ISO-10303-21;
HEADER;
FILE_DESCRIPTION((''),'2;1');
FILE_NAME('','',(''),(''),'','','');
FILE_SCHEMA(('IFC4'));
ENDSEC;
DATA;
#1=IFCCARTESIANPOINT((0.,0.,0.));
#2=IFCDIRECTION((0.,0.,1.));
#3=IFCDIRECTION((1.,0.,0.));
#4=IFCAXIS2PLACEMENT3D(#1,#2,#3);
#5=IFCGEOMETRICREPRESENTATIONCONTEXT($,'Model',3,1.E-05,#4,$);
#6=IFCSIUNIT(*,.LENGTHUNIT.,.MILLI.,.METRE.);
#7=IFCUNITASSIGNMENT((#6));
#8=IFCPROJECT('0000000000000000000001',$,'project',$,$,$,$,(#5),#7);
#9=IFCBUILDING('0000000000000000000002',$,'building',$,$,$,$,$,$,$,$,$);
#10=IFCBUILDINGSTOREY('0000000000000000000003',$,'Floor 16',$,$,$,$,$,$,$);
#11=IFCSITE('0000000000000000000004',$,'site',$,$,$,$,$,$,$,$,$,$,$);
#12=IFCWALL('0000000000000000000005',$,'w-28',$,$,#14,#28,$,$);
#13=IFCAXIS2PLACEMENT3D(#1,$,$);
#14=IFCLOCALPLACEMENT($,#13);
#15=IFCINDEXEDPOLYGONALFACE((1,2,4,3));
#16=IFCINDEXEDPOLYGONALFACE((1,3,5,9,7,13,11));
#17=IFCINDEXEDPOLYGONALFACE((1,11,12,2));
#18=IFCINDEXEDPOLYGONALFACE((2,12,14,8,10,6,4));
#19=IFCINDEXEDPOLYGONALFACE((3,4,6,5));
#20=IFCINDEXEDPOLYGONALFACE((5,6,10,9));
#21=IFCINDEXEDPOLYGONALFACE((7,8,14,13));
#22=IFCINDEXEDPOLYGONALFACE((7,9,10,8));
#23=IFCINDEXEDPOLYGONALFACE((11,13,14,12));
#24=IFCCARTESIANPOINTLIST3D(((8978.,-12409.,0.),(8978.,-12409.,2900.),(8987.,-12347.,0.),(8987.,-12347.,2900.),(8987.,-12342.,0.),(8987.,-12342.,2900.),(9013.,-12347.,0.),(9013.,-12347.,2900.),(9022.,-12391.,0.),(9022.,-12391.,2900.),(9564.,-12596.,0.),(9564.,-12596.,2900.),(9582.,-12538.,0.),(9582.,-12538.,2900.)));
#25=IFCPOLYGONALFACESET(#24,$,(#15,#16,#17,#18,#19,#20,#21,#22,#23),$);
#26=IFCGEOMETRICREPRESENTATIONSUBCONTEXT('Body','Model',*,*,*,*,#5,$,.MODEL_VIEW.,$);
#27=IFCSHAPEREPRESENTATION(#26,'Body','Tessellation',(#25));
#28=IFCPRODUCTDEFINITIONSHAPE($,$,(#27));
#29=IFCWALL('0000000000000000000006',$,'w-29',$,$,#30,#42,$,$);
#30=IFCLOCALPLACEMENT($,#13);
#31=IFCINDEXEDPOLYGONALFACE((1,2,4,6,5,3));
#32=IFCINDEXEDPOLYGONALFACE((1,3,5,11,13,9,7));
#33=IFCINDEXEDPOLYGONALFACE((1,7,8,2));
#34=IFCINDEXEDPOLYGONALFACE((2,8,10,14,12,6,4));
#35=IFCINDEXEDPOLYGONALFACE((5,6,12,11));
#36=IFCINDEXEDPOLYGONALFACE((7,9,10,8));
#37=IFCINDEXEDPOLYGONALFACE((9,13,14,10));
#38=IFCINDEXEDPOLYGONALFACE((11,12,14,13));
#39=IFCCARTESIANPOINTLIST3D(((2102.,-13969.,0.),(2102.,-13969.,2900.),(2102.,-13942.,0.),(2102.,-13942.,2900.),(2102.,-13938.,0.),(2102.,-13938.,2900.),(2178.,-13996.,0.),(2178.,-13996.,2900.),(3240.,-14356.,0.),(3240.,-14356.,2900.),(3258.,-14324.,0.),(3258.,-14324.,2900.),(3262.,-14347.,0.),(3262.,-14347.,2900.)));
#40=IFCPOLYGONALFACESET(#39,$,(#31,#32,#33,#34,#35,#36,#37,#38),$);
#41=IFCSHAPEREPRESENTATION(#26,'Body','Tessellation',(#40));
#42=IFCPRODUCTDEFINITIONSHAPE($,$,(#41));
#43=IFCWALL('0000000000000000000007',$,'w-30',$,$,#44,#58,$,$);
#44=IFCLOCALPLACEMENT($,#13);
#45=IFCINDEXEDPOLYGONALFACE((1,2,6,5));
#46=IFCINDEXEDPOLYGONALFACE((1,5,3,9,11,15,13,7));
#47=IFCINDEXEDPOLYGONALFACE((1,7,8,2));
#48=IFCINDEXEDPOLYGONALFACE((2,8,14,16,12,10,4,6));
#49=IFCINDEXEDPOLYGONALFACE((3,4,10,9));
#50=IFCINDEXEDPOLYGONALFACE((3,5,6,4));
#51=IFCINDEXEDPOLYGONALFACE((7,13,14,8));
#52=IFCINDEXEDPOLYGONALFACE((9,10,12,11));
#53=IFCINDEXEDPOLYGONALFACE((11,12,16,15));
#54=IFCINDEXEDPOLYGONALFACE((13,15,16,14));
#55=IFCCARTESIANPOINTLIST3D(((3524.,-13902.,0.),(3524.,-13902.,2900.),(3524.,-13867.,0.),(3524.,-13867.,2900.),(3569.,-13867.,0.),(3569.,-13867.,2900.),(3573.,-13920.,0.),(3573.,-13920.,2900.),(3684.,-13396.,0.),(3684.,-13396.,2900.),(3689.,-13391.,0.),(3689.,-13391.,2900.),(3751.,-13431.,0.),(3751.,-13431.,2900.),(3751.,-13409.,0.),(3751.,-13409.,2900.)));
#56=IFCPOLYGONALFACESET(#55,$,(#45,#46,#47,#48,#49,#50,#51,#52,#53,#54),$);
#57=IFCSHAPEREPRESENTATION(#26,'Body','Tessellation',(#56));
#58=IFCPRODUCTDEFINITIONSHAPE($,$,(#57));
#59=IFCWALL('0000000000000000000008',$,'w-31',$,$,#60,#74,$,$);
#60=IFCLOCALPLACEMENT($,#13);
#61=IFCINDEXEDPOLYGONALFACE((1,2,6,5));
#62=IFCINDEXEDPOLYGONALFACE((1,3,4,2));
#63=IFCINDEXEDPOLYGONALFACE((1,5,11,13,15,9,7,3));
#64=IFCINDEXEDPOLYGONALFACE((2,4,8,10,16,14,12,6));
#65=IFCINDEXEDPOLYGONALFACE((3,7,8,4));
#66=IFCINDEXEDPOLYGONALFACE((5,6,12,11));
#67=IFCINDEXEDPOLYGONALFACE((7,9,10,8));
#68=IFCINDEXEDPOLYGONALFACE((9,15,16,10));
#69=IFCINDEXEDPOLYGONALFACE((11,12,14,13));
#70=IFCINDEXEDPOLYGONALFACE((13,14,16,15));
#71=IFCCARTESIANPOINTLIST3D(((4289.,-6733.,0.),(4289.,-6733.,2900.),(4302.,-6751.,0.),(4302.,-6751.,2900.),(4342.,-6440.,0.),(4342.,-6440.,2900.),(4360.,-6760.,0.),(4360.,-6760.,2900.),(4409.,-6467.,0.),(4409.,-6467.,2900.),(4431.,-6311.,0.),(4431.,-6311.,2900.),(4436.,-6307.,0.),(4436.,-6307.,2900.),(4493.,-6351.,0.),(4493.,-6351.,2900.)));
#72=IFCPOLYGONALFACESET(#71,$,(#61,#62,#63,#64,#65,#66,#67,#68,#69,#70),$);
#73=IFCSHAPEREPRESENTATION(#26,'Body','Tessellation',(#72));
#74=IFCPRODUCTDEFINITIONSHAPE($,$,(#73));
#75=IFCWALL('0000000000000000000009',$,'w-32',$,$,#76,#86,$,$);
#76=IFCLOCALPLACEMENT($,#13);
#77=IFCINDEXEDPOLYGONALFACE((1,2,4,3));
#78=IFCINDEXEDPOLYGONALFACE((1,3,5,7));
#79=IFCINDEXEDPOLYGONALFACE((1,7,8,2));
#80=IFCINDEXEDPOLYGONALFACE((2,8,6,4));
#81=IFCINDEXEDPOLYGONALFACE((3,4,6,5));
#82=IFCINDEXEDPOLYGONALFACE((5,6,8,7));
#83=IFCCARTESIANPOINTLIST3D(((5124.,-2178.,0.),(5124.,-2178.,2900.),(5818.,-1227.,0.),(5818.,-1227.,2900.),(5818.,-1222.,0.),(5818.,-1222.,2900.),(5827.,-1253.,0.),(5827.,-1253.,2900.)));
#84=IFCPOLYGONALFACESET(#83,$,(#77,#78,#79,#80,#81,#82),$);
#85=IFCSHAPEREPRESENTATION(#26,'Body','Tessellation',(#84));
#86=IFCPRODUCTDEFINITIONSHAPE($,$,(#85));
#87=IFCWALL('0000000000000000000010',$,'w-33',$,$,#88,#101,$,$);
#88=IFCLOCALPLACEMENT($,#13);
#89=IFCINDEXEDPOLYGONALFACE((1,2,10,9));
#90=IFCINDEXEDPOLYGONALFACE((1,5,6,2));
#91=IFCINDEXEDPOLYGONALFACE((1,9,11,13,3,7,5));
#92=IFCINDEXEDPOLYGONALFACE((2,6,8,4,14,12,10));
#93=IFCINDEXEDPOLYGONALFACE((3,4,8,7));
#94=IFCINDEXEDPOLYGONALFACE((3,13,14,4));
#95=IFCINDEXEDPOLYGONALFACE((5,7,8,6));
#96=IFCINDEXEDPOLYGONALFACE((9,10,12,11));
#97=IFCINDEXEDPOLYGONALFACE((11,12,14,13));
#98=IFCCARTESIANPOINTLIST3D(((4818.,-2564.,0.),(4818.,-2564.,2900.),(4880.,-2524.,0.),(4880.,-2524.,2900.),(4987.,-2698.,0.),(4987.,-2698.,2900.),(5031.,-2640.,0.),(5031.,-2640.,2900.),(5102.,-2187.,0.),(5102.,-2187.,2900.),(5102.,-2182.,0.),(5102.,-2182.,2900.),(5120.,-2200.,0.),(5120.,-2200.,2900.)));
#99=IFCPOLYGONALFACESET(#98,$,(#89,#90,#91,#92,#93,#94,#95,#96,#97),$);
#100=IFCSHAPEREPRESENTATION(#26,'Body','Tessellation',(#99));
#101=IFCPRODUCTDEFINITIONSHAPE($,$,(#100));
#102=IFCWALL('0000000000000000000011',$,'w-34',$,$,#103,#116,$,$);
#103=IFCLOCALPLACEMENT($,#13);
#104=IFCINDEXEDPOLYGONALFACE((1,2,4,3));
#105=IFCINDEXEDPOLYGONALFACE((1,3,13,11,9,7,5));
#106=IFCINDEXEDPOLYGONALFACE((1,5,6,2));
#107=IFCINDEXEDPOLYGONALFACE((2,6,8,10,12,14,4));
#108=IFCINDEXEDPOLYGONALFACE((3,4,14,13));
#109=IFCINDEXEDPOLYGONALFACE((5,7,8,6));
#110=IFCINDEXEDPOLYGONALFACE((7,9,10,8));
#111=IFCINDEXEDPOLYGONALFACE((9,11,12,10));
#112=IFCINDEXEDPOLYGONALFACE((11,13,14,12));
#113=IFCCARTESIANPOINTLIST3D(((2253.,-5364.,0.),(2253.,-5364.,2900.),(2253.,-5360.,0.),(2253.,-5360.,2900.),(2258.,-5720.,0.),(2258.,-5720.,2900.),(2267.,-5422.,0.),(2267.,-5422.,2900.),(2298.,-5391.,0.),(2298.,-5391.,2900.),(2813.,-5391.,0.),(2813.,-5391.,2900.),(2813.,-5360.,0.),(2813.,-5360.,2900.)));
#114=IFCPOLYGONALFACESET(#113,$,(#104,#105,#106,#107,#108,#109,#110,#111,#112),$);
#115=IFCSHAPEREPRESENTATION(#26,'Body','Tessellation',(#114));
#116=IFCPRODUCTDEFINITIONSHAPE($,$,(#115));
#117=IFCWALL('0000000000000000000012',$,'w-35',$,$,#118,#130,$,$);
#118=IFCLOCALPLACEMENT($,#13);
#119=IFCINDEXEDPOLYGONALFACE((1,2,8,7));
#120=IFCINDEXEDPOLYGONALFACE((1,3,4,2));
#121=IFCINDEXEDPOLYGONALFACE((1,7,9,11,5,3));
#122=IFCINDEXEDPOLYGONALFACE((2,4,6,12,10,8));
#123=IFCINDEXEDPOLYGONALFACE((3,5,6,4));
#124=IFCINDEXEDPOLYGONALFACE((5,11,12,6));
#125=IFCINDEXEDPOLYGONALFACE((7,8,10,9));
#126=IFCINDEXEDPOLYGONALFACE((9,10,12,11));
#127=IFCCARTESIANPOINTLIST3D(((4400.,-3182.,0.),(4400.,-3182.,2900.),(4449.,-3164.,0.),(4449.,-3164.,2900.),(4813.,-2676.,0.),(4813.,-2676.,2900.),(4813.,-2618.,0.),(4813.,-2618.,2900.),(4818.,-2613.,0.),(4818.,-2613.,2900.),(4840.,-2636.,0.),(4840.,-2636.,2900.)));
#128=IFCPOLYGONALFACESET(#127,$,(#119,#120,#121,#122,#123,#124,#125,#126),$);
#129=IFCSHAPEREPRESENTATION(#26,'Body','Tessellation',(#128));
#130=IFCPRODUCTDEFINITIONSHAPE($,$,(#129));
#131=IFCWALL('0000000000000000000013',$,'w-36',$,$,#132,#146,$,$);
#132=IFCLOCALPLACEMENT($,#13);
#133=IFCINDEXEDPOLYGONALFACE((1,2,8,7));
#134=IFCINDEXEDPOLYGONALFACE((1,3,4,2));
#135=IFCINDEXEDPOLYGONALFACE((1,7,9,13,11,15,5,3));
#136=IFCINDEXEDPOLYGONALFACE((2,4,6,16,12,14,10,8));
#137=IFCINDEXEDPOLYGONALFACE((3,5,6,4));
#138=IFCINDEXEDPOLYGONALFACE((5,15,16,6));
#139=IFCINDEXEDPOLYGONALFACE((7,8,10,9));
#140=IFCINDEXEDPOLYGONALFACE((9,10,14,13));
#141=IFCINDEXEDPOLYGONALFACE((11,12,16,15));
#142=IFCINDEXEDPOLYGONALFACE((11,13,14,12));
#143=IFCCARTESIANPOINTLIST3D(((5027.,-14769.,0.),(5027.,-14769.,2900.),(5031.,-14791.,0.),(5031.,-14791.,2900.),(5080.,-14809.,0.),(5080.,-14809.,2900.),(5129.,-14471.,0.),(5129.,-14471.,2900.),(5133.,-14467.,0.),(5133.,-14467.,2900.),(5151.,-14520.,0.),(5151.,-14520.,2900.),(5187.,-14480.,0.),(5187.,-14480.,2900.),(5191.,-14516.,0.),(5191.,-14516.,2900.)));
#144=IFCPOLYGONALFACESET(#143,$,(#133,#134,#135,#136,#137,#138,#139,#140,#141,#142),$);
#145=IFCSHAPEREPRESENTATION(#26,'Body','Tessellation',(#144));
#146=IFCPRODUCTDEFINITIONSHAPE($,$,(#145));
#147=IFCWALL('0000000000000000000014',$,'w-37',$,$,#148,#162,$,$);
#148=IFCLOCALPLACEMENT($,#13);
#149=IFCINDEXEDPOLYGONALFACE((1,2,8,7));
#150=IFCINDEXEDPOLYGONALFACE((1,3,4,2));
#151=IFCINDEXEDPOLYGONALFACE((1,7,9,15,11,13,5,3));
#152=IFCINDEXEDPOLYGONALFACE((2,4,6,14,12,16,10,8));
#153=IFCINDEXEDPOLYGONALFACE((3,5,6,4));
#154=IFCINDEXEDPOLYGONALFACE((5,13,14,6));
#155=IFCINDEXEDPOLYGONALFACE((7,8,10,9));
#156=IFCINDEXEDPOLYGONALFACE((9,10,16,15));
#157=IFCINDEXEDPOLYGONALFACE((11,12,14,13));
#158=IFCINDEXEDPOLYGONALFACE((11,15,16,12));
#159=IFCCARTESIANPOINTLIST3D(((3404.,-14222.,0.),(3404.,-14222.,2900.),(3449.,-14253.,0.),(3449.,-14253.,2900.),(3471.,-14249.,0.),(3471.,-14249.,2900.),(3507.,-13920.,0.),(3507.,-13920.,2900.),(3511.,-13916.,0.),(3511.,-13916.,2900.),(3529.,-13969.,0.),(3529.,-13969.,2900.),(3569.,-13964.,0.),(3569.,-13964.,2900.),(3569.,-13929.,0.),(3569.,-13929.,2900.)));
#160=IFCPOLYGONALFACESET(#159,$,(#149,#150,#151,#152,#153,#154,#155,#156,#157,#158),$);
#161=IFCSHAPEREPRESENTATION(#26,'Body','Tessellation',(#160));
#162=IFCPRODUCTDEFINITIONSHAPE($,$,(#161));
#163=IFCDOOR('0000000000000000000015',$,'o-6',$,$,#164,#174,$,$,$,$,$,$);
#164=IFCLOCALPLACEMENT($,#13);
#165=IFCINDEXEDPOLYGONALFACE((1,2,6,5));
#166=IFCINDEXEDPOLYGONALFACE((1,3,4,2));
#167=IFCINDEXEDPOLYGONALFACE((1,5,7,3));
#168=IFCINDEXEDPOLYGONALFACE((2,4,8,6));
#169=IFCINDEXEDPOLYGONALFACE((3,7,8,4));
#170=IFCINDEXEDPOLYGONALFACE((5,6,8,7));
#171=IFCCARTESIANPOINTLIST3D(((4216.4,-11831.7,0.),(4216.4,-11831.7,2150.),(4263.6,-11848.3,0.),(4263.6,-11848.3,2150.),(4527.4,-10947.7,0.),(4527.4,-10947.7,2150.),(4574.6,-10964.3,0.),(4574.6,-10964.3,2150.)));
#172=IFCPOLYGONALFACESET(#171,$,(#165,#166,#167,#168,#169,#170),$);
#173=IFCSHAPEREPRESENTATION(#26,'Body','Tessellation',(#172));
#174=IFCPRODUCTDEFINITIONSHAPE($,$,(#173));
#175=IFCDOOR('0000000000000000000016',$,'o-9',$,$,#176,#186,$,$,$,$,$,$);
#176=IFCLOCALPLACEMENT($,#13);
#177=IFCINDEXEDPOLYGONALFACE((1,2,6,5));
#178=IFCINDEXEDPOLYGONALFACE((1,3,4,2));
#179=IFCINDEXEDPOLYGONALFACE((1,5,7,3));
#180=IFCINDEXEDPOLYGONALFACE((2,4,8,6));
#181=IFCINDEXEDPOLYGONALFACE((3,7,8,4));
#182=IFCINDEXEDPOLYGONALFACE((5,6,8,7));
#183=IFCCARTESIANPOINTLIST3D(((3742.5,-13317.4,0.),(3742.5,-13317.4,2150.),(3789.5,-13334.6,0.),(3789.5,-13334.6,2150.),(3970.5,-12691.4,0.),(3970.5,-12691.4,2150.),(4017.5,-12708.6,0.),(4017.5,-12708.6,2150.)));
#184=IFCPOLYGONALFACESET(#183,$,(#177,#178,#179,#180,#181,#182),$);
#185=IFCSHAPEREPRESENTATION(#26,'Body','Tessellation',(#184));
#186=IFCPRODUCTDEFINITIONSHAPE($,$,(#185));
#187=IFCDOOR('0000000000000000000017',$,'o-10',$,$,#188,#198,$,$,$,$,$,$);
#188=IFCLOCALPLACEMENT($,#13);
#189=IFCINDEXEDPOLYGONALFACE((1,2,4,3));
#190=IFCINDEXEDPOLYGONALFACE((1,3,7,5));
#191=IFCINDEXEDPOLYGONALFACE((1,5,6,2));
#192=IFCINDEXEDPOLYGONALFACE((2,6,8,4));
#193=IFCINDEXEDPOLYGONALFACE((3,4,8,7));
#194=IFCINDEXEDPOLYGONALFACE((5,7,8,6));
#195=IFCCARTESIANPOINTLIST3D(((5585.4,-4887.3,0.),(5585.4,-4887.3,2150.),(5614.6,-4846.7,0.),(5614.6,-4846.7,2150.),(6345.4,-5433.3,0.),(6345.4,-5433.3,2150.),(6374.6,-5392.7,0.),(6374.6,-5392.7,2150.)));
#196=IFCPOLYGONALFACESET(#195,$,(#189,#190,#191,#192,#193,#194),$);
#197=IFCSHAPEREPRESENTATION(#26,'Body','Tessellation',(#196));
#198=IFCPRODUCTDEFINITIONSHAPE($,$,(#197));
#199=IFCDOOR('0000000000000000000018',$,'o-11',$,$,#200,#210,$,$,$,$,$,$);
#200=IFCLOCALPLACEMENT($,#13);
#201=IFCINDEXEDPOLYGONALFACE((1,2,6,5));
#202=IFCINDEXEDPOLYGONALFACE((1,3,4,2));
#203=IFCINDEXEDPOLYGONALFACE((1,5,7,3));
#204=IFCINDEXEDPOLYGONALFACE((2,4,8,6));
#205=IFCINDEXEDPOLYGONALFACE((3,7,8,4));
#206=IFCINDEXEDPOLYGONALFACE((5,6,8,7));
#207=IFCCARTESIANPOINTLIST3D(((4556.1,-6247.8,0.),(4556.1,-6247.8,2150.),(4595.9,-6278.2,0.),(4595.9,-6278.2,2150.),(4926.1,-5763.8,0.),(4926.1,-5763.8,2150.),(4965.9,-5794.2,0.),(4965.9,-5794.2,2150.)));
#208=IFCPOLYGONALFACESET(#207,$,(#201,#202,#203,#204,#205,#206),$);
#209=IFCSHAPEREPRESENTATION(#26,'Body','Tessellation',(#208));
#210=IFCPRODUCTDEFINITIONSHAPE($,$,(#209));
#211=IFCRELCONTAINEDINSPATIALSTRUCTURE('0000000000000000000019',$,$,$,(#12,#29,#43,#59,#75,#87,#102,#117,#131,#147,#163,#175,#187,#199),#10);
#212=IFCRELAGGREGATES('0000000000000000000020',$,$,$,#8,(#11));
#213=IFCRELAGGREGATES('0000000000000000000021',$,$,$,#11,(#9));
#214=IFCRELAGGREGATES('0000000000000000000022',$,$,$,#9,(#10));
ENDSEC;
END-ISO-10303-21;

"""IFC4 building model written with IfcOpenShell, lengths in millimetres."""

from ifc_helpers import new_model, si_unit, origin_with_axes, place, context, subcontext, project, spatial, indexed_curve, outline, extrude, element, save


model = new_model("IFC4")

# Units and contexts
model_context = context("Model", 3, precision=1e-05, world=origin_with_axes())
body_context = subcontext(model_context, "Body", "Model", "MODEL_VIEW")
ifc_project = project(units=[si_unit("LENGTHUNIT", "METRE", prefix="MILLI")], contexts=[model_context])

# Site, building, storey
site = spatial("IfcSite", under=ifc_project, Name="site")
building = spatial("IfcBuilding", under=site, Name="building")
storey = spatial("IfcBuildingStorey", under=building, Name="Floor 16")

# Walls
wall_1_placement = place(None, origin_with_axes())
element("IfcWall", 1, at=wall_1_placement, inside=storey, Name="w-28", context=body_context, shape_type="SweptSolid", body=[
    extrude(outline(indexed_curve([(8987.0, -12342.0), (8987.0, -12347.0), (8978.0, -12409.0), (9564.0, -12596.0), (9582.0, -12538.0), (9013.0, -12347.0), (9022.0, -12391.0)])), None, (0.0, 0.0, 1.0), 2900.0),
])
wall_2_placement = place(None, origin_with_axes())
element("IfcWall", 2, at=wall_2_placement, inside=storey, Name="w-29", context=body_context, shape_type="SweptSolid", body=[
    extrude(outline(indexed_curve([(2102.0, -13938.0), (2102.0, -13942.0), (2102.0, -13969.0), (2178.0, -13996.0), (3240.0, -14356.0), (3262.0, -14347.0), (3258.0, -14324.0)])), None, (0.0, 0.0, 1.0), 2900.0),
])
wall_3_placement = place(None, origin_with_axes())
element("IfcWall", 3, at=wall_3_placement, inside=storey, Name="w-30", context=body_context, shape_type="SweptSolid", body=[
    extrude(outline(indexed_curve([(3689.0, -13391.0), (3684.0, -13396.0), (3524.0, -13867.0), (3569.0, -13867.0), (3524.0, -13902.0), (3573.0, -13920.0), (3751.0, -13431.0), (3751.0, -13409.0)])), None, (0.0, 0.0, 1.0), 2900.0),
])
wall_4_placement = place(None, origin_with_axes())
element("IfcWall", 4, at=wall_4_placement, inside=storey, Name="w-31", context=body_context, shape_type="SweptSolid", body=[
    extrude(outline(indexed_curve([(4436.0, -6307.0), (4431.0, -6311.0), (4342.0, -6440.0), (4289.0, -6733.0), (4302.0, -6751.0), (4360.0, -6760.0), (4409.0, -6467.0), (4493.0, -6351.0)])), None, (0.0, 0.0, 1.0), 2900.0),
])
wall_5_placement = place(None, origin_with_axes())
element("IfcWall", 5, at=wall_5_placement, inside=storey, Name="w-32", context=body_context, shape_type="SweptSolid", body=[
    extrude(outline(indexed_curve([(5818.0, -1222.0), (5818.0, -1227.0), (5124.0, -2178.0), (5827.0, -1253.0)])), None, (0.0, 0.0, 1.0), 2900.0),
])
wall_6_placement = place(None, origin_with_axes())
element("IfcWall", 6, at=wall_6_placement, inside=storey, Name="w-33", context=body_context, shape_type="SweptSolid", body=[
    extrude(outline(indexed_curve([(5102.0, -2182.0), (5102.0, -2187.0), (4818.0, -2564.0), (4987.0, -2698.0), (5031.0, -2640.0), (4880.0, -2524.0), (5120.0, -2200.0)])), None, (0.0, 0.0, 1.0), 2900.0),
])
wall_7_placement = place(None, origin_with_axes())
element("IfcWall", 7, at=wall_7_placement, inside=storey, Name="w-34", context=body_context, shape_type="SweptSolid", body=[
    extrude(outline(indexed_curve([(2253.0, -5360.0), (2253.0, -5364.0), (2258.0, -5720.0), (2267.0, -5422.0), (2298.0, -5391.0), (2813.0, -5391.0), (2813.0, -5360.0)])), None, (0.0, 0.0, 1.0), 2900.0),
])
wall_8_placement = place(None, origin_with_axes())
element("IfcWall", 8, at=wall_8_placement, inside=storey, Name="w-35", context=body_context, shape_type="SweptSolid", body=[
    extrude(outline(indexed_curve([(4818.0, -2613.0), (4813.0, -2618.0), (4400.0, -3182.0), (4449.0, -3164.0), (4813.0, -2676.0), (4840.0, -2636.0)])), None, (0.0, 0.0, 1.0), 2900.0),
])
wall_9_placement = place(None, origin_with_axes())
element("IfcWall", 9, at=wall_9_placement, inside=storey, Name="w-36", context=body_context, shape_type="SweptSolid", body=[
    extrude(outline(indexed_curve([(5133.0, -14467.0), (5129.0, -14471.0), (5027.0, -14769.0), (5031.0, -14791.0), (5080.0, -14809.0), (5191.0, -14516.0), (5151.0, -14520.0), (5187.0, -14480.0)])), None, (0.0, 0.0, 1.0), 2900.0),
])
wall_10_placement = place(None, origin_with_axes())
element("IfcWall", 10, at=wall_10_placement, inside=storey, Name="w-37", context=body_context, shape_type="SweptSolid", body=[
    extrude(outline(indexed_curve([(3511.0, -13916.0), (3507.0, -13920.0), (3404.0, -14222.0), (3449.0, -14253.0), (3471.0, -14249.0), (3569.0, -13964.0), (3529.0, -13969.0), (3569.0, -13929.0)])), None, (0.0, 0.0, 1.0), 2900.0),
])

# Doors
door_1_placement = place(None, origin_with_axes())
element("IfcDoor", 11, at=door_1_placement, inside=storey, Name="o-6", context=body_context, shape_type="SweptSolid", body=[
    extrude(outline(indexed_curve([(4216.4, -11831.7), (4527.4, -10947.7), (4574.6, -10964.3), (4263.6, -11848.3)])), None, (0.0, 0.0, 1.0), 2150.0),
])
door_2_placement = place(None, origin_with_axes())
element("IfcDoor", 12, at=door_2_placement, inside=storey, Name="o-9", context=body_context, shape_type="SweptSolid", body=[
    extrude(outline(indexed_curve([(3742.5, -13317.4), (3970.5, -12691.4), (4017.5, -12708.6), (3789.5, -13334.6)])), None, (0.0, 0.0, 1.0), 2150.0),
])
door_3_placement = place(None, origin_with_axes())
element("IfcDoor", 13, at=door_3_placement, inside=storey, Name="o-10", context=body_context, shape_type="SweptSolid", body=[
    extrude(outline(indexed_curve([(5614.6, -4846.7), (6374.6, -5392.7), (6345.4, -5433.3), (5585.4, -4887.3)])), None, (0.0, 0.0, 1.0), 2150.0),
])
door_4_placement = place(None, origin_with_axes())
element("IfcDoor", 14, at=door_4_placement, inside=storey, Name="o-11", context=body_context, shape_type="SweptSolid", body=[
    extrude(outline(indexed_curve([(4556.1, -6247.8), (4926.1, -5763.8), (4965.9, -5794.2), (4595.9, -6278.2)])), None, (0.0, 0.0, 1.0), 2150.0),
])

save(model, "model.ifc")
